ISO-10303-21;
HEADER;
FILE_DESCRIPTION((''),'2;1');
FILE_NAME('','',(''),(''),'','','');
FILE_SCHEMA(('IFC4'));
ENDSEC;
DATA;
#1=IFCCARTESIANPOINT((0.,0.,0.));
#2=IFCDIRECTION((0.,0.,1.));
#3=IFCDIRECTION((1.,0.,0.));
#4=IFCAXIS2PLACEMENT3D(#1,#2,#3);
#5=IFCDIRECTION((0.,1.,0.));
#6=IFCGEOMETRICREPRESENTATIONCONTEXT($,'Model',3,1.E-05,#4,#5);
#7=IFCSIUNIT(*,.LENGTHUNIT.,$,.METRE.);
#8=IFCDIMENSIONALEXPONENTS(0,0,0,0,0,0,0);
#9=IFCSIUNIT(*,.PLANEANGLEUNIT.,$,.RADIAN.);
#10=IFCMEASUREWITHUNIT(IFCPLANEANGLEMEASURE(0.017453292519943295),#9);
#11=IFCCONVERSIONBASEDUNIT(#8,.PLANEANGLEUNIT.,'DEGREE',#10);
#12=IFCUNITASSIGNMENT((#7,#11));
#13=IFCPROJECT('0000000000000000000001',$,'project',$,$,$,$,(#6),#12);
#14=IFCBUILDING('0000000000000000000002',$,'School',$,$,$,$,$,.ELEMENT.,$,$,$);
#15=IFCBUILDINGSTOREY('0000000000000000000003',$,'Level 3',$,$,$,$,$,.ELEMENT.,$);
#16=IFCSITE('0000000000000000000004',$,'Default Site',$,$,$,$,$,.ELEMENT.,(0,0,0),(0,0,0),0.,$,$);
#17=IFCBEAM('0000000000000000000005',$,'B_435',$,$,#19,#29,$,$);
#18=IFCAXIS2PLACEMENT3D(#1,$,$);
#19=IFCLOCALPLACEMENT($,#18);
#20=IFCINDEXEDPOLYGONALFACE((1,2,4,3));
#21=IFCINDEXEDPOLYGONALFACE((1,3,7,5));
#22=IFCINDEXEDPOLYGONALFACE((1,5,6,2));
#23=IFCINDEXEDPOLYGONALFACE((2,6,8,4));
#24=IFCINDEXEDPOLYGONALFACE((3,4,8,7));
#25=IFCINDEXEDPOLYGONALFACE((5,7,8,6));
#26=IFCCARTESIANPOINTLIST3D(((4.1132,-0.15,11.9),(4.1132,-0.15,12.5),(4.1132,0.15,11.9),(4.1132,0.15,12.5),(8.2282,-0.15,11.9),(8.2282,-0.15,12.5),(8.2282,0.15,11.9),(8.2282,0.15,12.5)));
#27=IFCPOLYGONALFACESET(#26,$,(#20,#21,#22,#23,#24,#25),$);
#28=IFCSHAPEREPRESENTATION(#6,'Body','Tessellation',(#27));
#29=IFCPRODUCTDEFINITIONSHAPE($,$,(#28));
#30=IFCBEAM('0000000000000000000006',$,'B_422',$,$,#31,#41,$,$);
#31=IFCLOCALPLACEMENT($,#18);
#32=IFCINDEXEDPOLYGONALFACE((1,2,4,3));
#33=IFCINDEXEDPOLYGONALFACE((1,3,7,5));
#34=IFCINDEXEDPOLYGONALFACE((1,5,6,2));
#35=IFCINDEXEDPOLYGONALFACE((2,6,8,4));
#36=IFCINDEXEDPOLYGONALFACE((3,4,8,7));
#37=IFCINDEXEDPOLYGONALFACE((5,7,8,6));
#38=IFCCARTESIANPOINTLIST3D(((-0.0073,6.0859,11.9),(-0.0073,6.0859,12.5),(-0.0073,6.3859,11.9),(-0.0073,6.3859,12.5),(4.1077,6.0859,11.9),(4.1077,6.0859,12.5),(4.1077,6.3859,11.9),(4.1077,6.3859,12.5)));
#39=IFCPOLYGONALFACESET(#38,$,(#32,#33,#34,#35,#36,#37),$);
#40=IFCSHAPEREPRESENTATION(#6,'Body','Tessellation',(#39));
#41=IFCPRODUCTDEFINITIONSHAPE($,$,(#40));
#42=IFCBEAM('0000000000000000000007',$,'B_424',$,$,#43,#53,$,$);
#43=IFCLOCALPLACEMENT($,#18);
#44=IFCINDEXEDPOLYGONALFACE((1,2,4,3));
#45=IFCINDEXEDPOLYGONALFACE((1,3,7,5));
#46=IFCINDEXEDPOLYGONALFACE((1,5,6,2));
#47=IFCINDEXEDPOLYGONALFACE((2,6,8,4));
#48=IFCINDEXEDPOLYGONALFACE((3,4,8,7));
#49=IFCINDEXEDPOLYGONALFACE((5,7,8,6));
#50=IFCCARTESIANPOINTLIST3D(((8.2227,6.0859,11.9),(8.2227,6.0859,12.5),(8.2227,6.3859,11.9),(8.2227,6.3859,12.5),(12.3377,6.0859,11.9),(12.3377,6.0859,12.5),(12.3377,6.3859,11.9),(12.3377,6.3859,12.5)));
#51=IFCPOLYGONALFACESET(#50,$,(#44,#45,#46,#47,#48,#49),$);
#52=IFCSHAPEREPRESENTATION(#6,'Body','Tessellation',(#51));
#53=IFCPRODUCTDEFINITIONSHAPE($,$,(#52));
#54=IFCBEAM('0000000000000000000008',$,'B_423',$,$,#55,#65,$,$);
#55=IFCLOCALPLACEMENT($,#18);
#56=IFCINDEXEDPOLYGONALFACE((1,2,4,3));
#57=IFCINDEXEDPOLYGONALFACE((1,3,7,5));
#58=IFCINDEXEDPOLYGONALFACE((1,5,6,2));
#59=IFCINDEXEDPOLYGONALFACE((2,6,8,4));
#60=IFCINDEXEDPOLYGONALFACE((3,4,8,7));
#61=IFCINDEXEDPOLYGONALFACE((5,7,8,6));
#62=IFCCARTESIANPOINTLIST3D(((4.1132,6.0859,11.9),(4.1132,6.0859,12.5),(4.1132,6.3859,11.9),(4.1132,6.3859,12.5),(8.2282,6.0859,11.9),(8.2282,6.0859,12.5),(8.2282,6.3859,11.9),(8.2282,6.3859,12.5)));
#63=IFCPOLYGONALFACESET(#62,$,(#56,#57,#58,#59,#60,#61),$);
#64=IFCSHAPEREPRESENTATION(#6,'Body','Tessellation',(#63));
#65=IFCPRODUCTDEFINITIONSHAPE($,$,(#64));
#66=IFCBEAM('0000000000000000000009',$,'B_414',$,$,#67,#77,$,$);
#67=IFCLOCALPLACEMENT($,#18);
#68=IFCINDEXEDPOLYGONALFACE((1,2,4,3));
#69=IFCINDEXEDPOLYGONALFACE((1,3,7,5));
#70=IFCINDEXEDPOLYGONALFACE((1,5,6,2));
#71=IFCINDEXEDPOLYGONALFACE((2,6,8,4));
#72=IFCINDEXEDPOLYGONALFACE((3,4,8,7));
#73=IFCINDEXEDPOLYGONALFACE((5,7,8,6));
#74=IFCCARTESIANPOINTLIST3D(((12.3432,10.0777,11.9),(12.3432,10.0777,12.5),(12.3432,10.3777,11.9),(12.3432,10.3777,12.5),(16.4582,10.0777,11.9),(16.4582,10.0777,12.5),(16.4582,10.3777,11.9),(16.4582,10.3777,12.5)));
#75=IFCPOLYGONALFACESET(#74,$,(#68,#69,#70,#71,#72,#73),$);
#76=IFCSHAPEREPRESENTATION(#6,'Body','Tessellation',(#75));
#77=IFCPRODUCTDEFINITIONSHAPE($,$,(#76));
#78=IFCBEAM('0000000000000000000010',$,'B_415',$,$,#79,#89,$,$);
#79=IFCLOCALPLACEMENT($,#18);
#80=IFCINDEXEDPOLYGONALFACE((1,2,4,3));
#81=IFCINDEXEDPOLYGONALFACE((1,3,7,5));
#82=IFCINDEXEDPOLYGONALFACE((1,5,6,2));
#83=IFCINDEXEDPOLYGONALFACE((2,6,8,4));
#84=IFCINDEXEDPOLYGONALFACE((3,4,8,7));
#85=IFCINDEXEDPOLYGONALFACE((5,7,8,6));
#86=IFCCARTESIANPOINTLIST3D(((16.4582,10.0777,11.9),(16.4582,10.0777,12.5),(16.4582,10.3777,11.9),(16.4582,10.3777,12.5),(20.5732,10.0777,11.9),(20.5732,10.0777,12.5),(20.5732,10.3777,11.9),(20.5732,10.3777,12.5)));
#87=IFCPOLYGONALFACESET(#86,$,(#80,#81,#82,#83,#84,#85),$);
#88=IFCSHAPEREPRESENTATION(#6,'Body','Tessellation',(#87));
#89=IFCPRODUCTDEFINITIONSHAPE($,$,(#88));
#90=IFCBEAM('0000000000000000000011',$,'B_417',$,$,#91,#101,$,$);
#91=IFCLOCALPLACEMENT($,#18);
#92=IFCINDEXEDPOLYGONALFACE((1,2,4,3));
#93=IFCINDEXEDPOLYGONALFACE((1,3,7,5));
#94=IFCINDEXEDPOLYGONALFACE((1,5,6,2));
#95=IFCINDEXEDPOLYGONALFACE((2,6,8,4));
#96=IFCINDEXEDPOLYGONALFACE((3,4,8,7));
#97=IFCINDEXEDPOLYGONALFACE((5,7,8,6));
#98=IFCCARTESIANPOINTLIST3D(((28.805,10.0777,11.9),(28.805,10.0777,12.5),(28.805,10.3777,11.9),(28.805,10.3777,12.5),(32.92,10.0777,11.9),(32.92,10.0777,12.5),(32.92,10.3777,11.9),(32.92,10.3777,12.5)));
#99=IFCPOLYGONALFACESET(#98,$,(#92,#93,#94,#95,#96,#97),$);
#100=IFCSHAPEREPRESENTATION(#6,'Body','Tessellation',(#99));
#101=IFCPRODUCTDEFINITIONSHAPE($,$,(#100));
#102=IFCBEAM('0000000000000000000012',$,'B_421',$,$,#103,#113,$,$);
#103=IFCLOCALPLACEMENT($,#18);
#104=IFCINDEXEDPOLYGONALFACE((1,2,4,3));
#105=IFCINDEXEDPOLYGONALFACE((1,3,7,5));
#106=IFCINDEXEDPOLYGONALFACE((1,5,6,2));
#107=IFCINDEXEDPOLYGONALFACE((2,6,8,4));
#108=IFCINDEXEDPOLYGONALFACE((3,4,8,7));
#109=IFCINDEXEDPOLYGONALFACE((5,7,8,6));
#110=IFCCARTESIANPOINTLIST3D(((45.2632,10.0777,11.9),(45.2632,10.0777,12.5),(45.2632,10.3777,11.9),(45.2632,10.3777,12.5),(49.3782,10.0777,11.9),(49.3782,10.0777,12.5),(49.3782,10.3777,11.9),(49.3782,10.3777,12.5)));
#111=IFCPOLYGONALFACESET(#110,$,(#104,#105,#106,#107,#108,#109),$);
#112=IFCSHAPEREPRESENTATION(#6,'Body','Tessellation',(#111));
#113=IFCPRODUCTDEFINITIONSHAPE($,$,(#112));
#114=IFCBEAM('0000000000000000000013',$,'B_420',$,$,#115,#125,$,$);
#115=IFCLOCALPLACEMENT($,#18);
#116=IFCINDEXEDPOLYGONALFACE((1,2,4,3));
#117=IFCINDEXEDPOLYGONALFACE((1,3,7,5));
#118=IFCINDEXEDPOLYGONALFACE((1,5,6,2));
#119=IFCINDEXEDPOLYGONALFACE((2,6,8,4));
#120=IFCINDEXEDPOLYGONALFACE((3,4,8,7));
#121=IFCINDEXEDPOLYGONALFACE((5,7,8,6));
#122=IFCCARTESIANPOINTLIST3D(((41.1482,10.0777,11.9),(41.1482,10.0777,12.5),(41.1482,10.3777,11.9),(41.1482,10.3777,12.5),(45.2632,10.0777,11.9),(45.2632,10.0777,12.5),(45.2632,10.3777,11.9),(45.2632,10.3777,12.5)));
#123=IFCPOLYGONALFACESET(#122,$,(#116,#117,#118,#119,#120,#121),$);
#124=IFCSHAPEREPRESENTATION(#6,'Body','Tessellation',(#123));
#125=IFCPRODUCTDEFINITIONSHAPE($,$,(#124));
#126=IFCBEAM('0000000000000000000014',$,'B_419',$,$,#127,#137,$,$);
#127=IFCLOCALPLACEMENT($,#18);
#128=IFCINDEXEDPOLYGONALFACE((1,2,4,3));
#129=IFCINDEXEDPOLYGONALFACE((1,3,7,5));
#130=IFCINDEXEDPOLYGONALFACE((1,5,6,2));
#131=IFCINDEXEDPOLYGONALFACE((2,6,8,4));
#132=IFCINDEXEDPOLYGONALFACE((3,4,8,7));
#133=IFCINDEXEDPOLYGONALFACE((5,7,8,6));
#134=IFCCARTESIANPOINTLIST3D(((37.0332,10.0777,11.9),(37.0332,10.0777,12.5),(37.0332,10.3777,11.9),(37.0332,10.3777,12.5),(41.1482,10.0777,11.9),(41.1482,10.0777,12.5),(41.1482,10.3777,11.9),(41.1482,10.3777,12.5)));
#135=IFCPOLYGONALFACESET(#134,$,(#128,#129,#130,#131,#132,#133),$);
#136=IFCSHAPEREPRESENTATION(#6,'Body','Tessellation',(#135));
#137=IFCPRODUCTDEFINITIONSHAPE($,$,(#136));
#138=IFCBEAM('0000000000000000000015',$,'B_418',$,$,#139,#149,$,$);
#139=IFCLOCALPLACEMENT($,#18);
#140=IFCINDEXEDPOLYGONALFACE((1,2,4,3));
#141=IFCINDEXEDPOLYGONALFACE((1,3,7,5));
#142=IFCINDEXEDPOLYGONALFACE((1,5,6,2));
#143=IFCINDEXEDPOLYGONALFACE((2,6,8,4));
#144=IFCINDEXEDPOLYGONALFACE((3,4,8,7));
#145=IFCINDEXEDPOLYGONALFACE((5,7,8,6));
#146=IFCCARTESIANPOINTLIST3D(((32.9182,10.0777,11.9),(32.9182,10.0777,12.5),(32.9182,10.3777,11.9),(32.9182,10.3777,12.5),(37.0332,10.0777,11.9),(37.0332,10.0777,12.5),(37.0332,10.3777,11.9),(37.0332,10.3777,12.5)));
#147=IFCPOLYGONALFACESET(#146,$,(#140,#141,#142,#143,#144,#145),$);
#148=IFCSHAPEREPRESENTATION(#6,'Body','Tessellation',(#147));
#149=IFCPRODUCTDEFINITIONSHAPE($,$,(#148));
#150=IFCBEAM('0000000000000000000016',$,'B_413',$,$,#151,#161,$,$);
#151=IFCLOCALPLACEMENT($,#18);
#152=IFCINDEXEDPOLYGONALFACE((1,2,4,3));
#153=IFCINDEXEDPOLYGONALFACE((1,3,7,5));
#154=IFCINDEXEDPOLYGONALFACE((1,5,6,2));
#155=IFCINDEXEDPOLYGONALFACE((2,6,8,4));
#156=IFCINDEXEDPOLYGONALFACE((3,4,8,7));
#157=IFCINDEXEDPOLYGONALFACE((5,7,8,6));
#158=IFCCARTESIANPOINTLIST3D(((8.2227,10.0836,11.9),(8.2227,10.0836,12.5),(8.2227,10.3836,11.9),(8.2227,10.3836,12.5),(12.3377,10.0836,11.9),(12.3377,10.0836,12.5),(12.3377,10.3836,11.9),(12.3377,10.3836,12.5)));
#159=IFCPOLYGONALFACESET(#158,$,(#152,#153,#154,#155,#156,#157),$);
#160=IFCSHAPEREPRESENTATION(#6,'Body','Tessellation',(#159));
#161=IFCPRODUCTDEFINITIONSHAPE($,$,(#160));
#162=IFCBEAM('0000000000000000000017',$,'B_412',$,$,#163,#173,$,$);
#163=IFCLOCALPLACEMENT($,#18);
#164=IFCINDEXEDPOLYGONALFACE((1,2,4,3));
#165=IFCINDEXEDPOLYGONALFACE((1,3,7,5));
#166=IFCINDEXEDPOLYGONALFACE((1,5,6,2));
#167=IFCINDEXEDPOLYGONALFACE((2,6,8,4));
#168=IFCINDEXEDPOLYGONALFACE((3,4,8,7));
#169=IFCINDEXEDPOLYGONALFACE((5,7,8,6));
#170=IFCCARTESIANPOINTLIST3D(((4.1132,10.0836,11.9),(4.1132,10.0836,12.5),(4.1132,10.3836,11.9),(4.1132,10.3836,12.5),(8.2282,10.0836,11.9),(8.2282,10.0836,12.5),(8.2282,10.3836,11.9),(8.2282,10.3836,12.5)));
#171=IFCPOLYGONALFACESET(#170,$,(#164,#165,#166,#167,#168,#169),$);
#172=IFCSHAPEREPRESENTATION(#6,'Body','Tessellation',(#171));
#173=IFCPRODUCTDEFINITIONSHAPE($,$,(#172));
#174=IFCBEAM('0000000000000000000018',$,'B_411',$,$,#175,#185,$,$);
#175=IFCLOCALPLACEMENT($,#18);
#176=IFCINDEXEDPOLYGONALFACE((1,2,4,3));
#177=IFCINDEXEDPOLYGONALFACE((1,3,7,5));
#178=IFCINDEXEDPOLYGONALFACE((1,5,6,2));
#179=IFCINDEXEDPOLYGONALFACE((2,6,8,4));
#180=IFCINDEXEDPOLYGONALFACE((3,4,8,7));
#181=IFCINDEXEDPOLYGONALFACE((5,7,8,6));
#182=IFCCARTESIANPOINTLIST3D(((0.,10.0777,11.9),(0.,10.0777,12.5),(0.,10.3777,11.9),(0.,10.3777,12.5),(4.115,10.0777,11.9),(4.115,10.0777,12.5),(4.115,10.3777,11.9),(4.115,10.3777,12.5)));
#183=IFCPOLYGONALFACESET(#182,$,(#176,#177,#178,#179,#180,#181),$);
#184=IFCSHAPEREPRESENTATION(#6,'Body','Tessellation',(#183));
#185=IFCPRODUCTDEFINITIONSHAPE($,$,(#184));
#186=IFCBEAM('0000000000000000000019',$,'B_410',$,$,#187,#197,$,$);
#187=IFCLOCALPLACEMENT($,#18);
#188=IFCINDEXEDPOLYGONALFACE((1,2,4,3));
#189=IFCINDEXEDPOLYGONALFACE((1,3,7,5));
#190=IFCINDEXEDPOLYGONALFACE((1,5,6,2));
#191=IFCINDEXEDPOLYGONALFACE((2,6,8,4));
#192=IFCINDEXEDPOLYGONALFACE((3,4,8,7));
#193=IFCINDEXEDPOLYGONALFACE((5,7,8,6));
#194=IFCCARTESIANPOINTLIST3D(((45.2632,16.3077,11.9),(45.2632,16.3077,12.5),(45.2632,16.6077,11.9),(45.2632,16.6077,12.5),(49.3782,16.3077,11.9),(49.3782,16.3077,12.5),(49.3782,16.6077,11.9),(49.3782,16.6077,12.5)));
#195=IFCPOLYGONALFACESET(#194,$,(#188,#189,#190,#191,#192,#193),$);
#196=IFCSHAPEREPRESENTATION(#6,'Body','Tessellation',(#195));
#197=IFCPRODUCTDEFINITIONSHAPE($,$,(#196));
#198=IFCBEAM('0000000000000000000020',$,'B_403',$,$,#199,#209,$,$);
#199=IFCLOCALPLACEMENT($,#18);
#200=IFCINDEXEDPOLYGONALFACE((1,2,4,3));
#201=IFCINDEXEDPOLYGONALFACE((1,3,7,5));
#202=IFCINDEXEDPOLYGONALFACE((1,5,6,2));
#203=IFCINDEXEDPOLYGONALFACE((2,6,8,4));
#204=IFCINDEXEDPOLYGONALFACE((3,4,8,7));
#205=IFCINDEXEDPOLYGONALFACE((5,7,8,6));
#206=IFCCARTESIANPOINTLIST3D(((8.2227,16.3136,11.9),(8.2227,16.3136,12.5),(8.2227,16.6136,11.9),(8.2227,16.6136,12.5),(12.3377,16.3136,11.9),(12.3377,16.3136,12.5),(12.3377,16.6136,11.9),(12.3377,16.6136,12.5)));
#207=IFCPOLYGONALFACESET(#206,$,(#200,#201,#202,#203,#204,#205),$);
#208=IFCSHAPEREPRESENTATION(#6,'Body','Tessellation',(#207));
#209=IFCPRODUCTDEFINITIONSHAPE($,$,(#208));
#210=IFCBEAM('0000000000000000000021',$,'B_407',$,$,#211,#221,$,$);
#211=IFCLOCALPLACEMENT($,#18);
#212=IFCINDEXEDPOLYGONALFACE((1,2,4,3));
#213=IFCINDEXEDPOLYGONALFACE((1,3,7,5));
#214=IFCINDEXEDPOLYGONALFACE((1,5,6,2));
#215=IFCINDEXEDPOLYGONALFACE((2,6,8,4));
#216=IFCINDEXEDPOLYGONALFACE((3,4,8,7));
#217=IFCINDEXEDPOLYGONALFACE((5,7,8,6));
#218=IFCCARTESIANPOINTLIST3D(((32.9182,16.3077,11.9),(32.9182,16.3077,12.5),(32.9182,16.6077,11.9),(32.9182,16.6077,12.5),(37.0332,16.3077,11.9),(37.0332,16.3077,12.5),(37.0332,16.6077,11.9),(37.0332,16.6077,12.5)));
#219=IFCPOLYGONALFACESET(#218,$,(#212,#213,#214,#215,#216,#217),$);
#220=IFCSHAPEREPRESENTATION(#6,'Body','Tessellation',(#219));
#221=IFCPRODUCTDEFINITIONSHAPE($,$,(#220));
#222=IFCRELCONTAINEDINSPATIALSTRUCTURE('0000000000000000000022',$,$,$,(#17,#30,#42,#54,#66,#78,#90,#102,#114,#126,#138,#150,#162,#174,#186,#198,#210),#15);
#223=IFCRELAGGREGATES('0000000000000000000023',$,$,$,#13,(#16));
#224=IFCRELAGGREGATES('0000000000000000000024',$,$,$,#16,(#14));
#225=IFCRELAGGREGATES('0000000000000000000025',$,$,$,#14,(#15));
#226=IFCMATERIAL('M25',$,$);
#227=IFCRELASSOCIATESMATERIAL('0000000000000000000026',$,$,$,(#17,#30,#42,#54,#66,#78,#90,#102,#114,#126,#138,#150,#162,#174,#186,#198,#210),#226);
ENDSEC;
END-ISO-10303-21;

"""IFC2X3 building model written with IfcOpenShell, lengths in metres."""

from ifc_helpers import new_model, entity, si_unit, converted_unit, direction, frame, frame_2d, origin_with_axes, place, context, project, spatial, rectangle, extrude, material, element, save


model = new_model("IFC2X3")

# Units and contexts
model_context = context("Model", 3, precision=1e-05, world=origin_with_axes(), true_north=direction((0.0, 1.0, 0.0)))
ifc_project = project(units=[si_unit("LENGTHUNIT", "METRE"), converted_unit("PLANEANGLEUNIT", "DEGREE", entity("IfcPlaneAngleMeasure", 0.017453292519943295), si_unit("PLANEANGLEUNIT", "RADIAN"), dimensions=[0, 0, 0, 0, 0, 0, 0])], contexts=[model_context])

# Site, building, storey
site = spatial("IfcSite", under=ifc_project, Name="Default Site", CompositionType="ELEMENT", RefLatitude=(0, 0, 0), RefLongitude=(0, 0, 0), RefElevation=0.0)
building = spatial("IfcBuilding", under=site, Name="School", CompositionType="ELEMENT")
storey = spatial("IfcBuildingStorey", under=building, Name="Level 3", CompositionType="ELEMENT")

# Beams
ifc_material = material(Name="M25")
placement = place(None, origin_with_axes())
element("IfcBeam", 1, at=placement, inside=storey, material=ifc_material, Name="B_435", context=model_context, shape_type="SweptSolid", body=[
    extrude(rectangle(XDim=0.3, YDim=0.6, at=frame_2d((0.0, 0.0), x_axis=(0.0, 1.0, 0.0))), frame((4.1132, 0.0, 12.2), z_axis=(1.0, 0.0, 0.0), x_axis=(0.0, 0.0, -1.0)), (0.0, 0.0, 1.0), 4.115),
])
element("IfcBeam", 2, at=placement, inside=storey, material=ifc_material, Name="B_422", context=model_context, shape_type="SweptSolid", body=[
    extrude(rectangle(XDim=0.3, YDim=0.6, at=frame_2d((0.0, 0.0), x_axis=(0.0, 1.0, 0.0))), frame((-0.0073, 6.2359, 12.2), z_axis=(1.0, 0.0, 0.0), x_axis=(0.0, 0.0, -1.0)), (0.0, 0.0, 1.0), 4.115),
])
element("IfcBeam", 3, at=placement, inside=storey, material=ifc_material, Name="B_424", context=model_context, shape_type="SweptSolid", body=[
    extrude(rectangle(XDim=0.3, YDim=0.6, at=frame_2d((0.0, 0.0), x_axis=(0.0, 1.0, 0.0))), frame((8.2227, 6.2359, 12.2), z_axis=(1.0, 0.0, 0.0), x_axis=(0.0, 0.0, -1.0)), (0.0, 0.0, 1.0), 4.115),
])
element("IfcBeam", 4, at=placement, inside=storey, material=ifc_material, Name="B_423", context=model_context, shape_type="SweptSolid", body=[
    extrude(rectangle(XDim=0.3, YDim=0.6, at=frame_2d((0.0, 0.0), x_axis=(0.0, 1.0, 0.0))), frame((4.1132, 6.2359, 12.2), z_axis=(1.0, 0.0, 0.0), x_axis=(0.0, 0.0, -1.0)), (0.0, 0.0, 1.0), 4.115),
])
element("IfcBeam", 5, at=placement, inside=storey, material=ifc_material, Name="B_414", context=model_context, shape_type="SweptSolid", body=[
    extrude(rectangle(XDim=0.3, YDim=0.6, at=frame_2d((0.0, 0.0), x_axis=(0.0, 1.0, 0.0))), frame((12.3432, 10.2277, 12.2), z_axis=(1.0, 0.0, 0.0), x_axis=(0.0, 0.0, -1.0)), (0.0, 0.0, 1.0), 4.115),
])
element("IfcBeam", 6, at=placement, inside=storey, material=ifc_material, Name="B_415", context=model_context, shape_type="SweptSolid", body=[
    extrude(rectangle(XDim=0.3, YDim=0.6, at=frame_2d((0.0, 0.0), x_axis=(0.0, 1.0, 0.0))), frame((16.4582, 10.2277, 12.2), z_axis=(1.0, 0.0, 0.0), x_axis=(0.0, 0.0, -1.0)), (0.0, 0.0, 1.0), 4.115),
])
element("IfcBeam", 7, at=placement, inside=storey, material=ifc_material, Name="B_417", context=model_context, shape_type="SweptSolid", body=[
    extrude(rectangle(XDim=0.3, YDim=0.6, at=frame_2d((0.0, 0.0), x_axis=(0.0, 1.0, 0.0))), frame((28.805, 10.2277, 12.2), z_axis=(1.0, 0.0, 0.0), x_axis=(0.0, 0.0, -1.0)), (0.0, 0.0, 1.0), 4.115),
])
element("IfcBeam", 8, at=placement, inside=storey, material=ifc_material, Name="B_421", context=model_context, shape_type="SweptSolid", body=[
    extrude(rectangle(XDim=0.3, YDim=0.6, at=frame_2d((0.0, 0.0), x_axis=(0.0, 1.0, 0.0))), frame((45.2632, 10.2277, 12.2), z_axis=(1.0, 0.0, 0.0), x_axis=(0.0, 0.0, -1.0)), (0.0, 0.0, 1.0), 4.115),
])
element("IfcBeam", 9, at=placement, inside=storey, material=ifc_material, Name="B_420", context=model_context, shape_type="SweptSolid", body=[
    extrude(rectangle(XDim=0.3, YDim=0.6, at=frame_2d((0.0, 0.0), x_axis=(0.0, 1.0, 0.0))), frame((41.1482, 10.2277, 12.2), z_axis=(1.0, 0.0, 0.0), x_axis=(0.0, 0.0, -1.0)), (0.0, 0.0, 1.0), 4.115),
])
element("IfcBeam", 10, at=placement, inside=storey, material=ifc_material, Name="B_419", context=model_context, shape_type="SweptSolid", body=[
    extrude(rectangle(XDim=0.3, YDim=0.6, at=frame_2d((0.0, 0.0), x_axis=(0.0, 1.0, 0.0))), frame((37.0332, 10.2277, 12.2), z_axis=(1.0, 0.0, 0.0), x_axis=(0.0, 0.0, -1.0)), (0.0, 0.0, 1.0), 4.115),
])
element("IfcBeam", 11, at=placement, inside=storey, material=ifc_material, Name="B_418", context=model_context, shape_type="SweptSolid", body=[
    extrude(rectangle(XDim=0.3, YDim=0.6, at=frame_2d((0.0, 0.0), x_axis=(0.0, 1.0, 0.0))), frame((32.9182, 10.2277, 12.2), z_axis=(1.0, 0.0, 0.0), x_axis=(0.0, 0.0, -1.0)), (0.0, 0.0, 1.0), 4.115),
])
element("IfcBeam", 12, at=placement, inside=storey, material=ifc_material, Name="B_413", context=model_context, shape_type="SweptSolid", body=[
    extrude(rectangle(XDim=0.3, YDim=0.6, at=frame_2d((0.0, 0.0), x_axis=(0.0, 1.0, 0.0))), frame((8.2227, 10.2336, 12.2), z_axis=(1.0, 0.0, 0.0), x_axis=(0.0, 0.0, -1.0)), (0.0, 0.0, 1.0), 4.115),
])
element("IfcBeam", 13, at=placement, inside=storey, material=ifc_material, Name="B_412", context=model_context, shape_type="SweptSolid", body=[
    extrude(rectangle(XDim=0.3, YDim=0.6, at=frame_2d((0.0, 0.0), x_axis=(0.0, 1.0, 0.0))), frame((4.1132, 10.2336, 12.2), z_axis=(1.0, 0.0, 0.0), x_axis=(0.0, 0.0, -1.0)), (0.0, 0.0, 1.0), 4.115),
])
element("IfcBeam", 14, at=placement, inside=storey, material=ifc_material, Name="B_411", context=model_context, shape_type="SweptSolid", body=[
    extrude(rectangle(XDim=0.3, YDim=0.6, at=frame_2d((0.0, 0.0), x_axis=(0.0, 1.0, 0.0))), frame((0.0, 10.2277, 12.2), z_axis=(1.0, 0.0, 0.0), x_axis=(0.0, 0.0, -1.0)), (0.0, 0.0, 1.0), 4.115),
])
element("IfcBeam", 15, at=placement, inside=storey, material=ifc_material, Name="B_410", context=model_context, shape_type="SweptSolid", body=[
    extrude(rectangle(XDim=0.3, YDim=0.6, at=frame_2d((0.0, 0.0), x_axis=(0.0, 1.0, 0.0))), frame((45.2632, 16.4577, 12.2), z_axis=(1.0, 0.0, 0.0), x_axis=(0.0, 0.0, -1.0)), (0.0, 0.0, 1.0), 4.115),
])
element("IfcBeam", 16, at=placement, inside=storey, material=ifc_material, Name="B_403", context=model_context, shape_type="SweptSolid", body=[
    extrude(rectangle(XDim=0.3, YDim=0.6, at=frame_2d((0.0, 0.0), x_axis=(0.0, 1.0, 0.0))), frame((8.2227, 16.4636, 12.2), z_axis=(1.0, 0.0, 0.0), x_axis=(0.0, 0.0, -1.0)), (0.0, 0.0, 1.0), 4.115),
])
element("IfcBeam", 17, at=placement, inside=storey, material=ifc_material, Name="B_407", context=model_context, shape_type="SweptSolid", body=[
    extrude(rectangle(XDim=0.3, YDim=0.6, at=frame_2d((0.0, 0.0), x_axis=(0.0, 1.0, 0.0))), frame((32.9182, 16.4577, 12.2), z_axis=(1.0, 0.0, 0.0), x_axis=(0.0, 0.0, -1.0)), (0.0, 0.0, 1.0), 4.115),
])

save(model, "model.ifc")
